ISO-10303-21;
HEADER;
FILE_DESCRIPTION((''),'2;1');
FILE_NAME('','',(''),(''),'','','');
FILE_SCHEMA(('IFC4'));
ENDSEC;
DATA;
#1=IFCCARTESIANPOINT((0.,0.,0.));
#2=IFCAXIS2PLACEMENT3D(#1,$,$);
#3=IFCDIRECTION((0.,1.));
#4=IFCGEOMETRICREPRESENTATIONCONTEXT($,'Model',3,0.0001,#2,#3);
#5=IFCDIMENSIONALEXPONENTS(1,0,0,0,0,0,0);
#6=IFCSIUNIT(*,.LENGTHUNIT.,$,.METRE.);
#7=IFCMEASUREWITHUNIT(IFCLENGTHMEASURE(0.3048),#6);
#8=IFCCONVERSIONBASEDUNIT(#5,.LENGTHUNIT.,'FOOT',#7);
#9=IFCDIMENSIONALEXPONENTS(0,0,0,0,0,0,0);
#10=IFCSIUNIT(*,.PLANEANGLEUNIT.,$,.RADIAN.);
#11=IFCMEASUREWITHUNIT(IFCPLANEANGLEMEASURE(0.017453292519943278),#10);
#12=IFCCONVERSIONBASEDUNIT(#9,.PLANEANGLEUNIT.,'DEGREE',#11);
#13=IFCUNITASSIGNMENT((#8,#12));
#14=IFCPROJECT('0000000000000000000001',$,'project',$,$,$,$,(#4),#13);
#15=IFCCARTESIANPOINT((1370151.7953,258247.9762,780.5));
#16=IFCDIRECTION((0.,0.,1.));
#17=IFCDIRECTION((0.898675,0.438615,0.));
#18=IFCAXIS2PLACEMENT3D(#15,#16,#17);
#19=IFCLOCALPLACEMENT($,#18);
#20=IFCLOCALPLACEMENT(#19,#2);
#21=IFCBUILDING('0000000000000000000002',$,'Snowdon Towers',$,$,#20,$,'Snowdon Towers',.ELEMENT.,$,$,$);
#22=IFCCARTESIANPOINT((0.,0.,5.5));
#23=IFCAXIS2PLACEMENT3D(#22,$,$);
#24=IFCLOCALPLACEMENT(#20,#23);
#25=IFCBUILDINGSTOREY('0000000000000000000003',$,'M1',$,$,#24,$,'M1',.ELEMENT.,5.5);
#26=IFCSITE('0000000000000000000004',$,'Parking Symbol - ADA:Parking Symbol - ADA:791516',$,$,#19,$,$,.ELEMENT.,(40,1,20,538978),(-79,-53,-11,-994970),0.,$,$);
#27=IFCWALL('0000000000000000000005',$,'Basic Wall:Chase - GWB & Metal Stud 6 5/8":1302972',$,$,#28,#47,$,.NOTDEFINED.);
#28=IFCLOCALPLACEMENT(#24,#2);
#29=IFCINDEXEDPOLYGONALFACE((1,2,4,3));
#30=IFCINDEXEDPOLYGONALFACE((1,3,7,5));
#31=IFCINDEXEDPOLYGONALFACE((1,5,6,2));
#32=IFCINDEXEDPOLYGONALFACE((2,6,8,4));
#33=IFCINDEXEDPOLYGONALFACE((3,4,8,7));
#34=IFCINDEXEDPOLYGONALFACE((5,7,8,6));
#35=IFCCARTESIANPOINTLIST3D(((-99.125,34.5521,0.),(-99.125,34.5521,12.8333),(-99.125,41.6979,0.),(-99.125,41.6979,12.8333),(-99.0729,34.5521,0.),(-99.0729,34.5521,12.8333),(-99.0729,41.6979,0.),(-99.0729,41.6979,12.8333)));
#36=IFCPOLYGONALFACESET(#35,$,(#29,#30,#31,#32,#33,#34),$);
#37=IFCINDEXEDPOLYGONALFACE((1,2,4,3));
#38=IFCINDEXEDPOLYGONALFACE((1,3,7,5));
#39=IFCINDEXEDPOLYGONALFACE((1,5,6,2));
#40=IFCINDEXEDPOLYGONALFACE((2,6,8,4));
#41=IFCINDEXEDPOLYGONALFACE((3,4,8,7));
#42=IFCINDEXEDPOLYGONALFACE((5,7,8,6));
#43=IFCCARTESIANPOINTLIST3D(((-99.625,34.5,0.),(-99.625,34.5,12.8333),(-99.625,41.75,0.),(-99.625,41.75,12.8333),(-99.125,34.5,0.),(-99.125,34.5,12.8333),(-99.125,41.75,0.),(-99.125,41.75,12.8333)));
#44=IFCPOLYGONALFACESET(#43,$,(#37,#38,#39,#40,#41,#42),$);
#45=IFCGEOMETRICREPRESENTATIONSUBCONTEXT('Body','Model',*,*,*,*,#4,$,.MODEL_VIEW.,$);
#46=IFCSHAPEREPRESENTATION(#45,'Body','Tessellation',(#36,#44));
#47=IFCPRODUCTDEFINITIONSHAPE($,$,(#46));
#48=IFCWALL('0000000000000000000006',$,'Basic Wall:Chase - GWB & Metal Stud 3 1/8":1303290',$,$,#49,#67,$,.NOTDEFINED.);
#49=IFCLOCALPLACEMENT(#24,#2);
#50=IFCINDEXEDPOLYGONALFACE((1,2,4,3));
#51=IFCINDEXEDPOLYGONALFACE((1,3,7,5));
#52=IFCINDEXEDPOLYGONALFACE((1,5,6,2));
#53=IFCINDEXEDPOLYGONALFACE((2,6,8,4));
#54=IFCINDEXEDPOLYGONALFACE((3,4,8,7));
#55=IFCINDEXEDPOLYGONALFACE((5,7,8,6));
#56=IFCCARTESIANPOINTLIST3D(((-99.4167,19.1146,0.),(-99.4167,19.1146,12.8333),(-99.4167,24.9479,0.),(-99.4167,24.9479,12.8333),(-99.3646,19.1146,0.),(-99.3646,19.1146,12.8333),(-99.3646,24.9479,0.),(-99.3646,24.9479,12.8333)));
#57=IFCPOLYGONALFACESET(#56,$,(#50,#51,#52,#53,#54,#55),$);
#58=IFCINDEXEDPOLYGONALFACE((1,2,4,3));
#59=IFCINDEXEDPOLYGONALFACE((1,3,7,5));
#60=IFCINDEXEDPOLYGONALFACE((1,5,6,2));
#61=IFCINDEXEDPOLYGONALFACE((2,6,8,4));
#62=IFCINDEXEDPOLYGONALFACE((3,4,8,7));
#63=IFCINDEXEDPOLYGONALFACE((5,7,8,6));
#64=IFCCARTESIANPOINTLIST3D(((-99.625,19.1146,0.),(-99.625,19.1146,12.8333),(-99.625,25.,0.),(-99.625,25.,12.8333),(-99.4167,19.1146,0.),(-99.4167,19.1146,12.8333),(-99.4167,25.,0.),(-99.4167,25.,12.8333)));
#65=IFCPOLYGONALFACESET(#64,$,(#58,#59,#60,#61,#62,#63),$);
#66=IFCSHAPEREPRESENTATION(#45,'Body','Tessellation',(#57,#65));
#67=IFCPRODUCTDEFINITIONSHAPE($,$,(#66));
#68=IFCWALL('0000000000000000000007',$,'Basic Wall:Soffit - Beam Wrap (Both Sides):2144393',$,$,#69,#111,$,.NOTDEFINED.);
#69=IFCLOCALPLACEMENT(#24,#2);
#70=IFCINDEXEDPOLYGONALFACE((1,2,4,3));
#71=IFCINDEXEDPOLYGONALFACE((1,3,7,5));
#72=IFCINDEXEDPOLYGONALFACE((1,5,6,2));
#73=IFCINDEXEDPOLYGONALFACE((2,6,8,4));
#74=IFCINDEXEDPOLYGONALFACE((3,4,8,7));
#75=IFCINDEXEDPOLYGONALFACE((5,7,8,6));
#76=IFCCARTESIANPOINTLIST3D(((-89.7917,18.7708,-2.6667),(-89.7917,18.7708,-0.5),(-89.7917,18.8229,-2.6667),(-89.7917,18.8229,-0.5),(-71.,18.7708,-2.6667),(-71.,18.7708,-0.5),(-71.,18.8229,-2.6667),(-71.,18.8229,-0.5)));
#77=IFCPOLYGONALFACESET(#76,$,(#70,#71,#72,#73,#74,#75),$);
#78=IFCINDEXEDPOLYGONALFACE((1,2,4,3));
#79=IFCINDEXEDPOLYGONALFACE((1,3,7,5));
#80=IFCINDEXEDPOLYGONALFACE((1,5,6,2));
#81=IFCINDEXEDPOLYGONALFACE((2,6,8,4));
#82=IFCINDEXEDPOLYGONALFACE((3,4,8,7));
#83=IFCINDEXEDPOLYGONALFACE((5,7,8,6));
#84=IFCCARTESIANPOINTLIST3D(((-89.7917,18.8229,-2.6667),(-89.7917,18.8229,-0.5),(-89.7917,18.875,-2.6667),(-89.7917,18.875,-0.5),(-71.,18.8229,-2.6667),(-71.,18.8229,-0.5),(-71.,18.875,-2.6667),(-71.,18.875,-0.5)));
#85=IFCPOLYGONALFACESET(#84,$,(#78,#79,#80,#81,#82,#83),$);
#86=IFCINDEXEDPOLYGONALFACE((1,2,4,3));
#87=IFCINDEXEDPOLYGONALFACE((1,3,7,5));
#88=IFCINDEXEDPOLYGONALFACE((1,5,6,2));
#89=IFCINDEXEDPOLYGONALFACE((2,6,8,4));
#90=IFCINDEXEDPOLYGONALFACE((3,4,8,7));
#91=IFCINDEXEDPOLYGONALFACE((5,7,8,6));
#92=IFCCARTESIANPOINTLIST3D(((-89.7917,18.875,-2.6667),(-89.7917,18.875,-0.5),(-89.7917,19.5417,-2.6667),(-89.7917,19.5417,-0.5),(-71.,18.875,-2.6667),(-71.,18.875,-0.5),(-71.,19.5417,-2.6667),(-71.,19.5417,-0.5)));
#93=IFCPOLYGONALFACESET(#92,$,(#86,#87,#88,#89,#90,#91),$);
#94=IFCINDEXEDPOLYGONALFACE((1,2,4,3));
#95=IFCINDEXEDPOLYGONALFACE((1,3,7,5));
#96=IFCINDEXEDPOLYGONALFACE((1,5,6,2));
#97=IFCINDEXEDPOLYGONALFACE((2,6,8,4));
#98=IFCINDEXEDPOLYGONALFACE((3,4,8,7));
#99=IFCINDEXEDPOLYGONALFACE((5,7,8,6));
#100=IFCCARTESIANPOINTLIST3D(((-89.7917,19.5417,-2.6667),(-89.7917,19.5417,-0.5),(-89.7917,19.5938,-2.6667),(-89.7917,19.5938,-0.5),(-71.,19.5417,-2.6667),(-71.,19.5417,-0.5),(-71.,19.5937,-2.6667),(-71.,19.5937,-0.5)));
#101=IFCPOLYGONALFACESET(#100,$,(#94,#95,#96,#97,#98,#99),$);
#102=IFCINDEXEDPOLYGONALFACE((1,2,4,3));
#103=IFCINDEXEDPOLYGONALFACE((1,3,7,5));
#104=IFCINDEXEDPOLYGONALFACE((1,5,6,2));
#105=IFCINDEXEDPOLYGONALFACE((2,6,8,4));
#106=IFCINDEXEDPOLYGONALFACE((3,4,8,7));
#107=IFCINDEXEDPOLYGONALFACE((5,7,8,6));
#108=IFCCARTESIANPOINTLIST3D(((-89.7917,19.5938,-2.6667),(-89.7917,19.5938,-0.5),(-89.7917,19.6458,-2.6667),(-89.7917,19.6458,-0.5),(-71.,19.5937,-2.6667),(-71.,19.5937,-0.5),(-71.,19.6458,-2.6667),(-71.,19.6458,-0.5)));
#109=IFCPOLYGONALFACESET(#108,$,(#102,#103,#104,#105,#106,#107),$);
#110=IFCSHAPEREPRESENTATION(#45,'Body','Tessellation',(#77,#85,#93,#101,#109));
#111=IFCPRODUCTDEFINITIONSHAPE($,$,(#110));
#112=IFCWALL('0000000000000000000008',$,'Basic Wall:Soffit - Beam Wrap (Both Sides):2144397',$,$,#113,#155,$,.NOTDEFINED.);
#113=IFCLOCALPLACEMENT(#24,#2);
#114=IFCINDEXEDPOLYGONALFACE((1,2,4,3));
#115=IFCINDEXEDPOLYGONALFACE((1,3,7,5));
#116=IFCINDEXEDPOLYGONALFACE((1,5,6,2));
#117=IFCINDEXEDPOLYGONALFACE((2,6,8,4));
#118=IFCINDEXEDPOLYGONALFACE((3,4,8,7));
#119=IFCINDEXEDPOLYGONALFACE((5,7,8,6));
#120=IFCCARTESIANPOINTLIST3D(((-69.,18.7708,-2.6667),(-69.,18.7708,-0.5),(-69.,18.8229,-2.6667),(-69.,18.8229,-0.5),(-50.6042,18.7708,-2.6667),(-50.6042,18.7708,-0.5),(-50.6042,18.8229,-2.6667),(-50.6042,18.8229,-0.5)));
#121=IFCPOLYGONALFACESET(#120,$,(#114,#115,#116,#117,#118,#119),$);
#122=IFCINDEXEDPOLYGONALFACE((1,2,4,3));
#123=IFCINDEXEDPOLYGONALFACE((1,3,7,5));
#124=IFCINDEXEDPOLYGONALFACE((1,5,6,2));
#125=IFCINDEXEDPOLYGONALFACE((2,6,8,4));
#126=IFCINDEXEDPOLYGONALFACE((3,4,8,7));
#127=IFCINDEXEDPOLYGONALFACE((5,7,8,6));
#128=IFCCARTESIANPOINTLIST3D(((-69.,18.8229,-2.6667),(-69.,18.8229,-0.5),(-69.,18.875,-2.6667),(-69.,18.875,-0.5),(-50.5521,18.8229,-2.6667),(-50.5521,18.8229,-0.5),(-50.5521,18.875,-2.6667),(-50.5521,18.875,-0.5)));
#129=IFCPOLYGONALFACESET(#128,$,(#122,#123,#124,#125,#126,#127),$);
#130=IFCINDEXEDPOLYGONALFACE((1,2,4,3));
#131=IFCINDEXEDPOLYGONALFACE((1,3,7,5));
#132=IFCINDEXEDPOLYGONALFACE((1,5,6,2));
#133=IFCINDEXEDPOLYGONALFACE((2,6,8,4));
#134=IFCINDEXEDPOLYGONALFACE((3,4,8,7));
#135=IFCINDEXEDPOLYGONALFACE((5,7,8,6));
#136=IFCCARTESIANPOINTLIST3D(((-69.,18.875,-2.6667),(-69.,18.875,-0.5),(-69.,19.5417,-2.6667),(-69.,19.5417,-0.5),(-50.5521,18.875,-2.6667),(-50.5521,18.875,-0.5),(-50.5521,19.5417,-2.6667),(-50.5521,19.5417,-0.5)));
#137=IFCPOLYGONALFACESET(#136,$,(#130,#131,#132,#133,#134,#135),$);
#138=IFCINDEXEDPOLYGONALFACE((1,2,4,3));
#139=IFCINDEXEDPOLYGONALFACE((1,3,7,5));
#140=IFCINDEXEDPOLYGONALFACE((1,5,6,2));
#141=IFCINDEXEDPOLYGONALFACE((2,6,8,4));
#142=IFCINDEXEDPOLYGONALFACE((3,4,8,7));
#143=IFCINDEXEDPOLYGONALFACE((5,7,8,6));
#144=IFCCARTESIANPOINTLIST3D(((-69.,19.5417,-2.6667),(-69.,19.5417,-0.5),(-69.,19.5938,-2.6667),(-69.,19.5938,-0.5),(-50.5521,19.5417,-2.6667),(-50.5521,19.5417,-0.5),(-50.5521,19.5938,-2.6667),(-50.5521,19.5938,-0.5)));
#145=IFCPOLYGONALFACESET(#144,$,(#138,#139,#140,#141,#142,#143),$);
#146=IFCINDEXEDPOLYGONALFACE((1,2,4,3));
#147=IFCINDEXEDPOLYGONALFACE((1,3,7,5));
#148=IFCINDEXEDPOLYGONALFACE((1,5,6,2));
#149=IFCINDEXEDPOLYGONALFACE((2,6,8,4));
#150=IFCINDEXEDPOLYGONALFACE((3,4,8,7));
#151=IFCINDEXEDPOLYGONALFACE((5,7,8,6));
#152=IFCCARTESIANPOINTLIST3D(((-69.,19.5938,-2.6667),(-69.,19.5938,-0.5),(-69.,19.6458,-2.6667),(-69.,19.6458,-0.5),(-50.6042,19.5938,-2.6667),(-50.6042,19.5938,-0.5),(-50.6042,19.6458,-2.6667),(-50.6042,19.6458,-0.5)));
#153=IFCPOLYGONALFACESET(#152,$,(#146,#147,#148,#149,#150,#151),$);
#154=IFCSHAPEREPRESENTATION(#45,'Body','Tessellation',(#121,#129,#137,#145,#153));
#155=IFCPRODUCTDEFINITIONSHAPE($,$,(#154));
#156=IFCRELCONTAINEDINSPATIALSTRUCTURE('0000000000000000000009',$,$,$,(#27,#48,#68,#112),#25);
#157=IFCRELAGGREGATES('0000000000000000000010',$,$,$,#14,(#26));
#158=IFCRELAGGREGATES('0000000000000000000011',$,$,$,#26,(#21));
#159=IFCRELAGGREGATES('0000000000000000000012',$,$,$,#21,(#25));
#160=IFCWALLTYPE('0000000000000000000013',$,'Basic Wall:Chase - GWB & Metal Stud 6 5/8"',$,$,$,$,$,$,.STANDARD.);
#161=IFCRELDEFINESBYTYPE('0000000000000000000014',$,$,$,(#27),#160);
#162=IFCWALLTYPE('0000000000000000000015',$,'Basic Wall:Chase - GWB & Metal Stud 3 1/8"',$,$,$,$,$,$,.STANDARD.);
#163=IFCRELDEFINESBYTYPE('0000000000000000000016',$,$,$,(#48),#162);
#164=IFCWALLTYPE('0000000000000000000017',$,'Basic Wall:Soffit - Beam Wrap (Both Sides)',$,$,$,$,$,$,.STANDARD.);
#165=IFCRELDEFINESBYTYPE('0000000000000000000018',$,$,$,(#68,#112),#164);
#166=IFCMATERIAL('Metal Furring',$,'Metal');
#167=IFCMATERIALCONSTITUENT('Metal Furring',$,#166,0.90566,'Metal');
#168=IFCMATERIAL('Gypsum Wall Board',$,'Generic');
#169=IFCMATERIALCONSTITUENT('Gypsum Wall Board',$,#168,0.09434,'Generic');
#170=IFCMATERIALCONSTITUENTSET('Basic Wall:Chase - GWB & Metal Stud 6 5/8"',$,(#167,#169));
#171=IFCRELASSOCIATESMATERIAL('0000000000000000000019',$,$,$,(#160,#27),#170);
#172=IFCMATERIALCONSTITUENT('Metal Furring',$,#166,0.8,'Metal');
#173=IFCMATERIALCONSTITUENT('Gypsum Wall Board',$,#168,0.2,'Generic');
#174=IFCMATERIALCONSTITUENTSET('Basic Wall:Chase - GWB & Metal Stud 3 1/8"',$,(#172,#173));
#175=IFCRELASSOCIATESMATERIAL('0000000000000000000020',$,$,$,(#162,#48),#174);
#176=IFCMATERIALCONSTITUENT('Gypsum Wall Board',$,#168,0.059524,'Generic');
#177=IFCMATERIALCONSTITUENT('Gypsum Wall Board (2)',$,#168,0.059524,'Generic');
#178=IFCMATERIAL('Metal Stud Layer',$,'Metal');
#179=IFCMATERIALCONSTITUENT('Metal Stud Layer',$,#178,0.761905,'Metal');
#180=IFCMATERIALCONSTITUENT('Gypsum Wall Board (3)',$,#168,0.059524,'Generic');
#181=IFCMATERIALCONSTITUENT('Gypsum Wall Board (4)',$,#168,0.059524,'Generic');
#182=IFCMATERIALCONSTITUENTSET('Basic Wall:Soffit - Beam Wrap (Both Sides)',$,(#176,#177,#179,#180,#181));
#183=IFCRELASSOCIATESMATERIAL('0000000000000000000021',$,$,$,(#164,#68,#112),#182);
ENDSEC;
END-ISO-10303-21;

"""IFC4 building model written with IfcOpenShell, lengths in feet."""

from ifc_helpers import new_model, entity, si_unit, converted_unit, direction, frame, origin, place, context, subcontext, project, spatial, indexed_curve, outline, extrude, material, constituent, constituent_set, type_object, element, save


model = new_model("IFC4")

# Units and contexts
model_context = context("Model", 3, precision=0.0001, world=origin(), true_north=direction((0.0, 1.0)))
body_context = subcontext(model_context, "Body", "Model", "MODEL_VIEW")
ifc_project = project(units=[converted_unit("LENGTHUNIT", "FOOT", entity("IfcLengthMeasure", 0.3048), si_unit("LENGTHUNIT", "METRE"), dimensions=[1, 0, 0, 0, 0, 0, 0]), converted_unit("PLANEANGLEUNIT", "DEGREE", entity("IfcPlaneAngleMeasure", 0.017453292519943278), si_unit("PLANEANGLEUNIT", "RADIAN"), dimensions=[0, 0, 0, 0, 0, 0, 0])], contexts=[model_context])

# Site, building, storey
site_placement = place(None, frame((1370151.7953, 258247.9762, 780.5), z_axis=(0.0, 0.0, 1.0), x_axis=(0.898675, 0.438615, 0.0)))
site = spatial("IfcSite", under=ifc_project, at=site_placement, Name="Parking Symbol - ADA:Parking Symbol - ADA:791516", CompositionType="ELEMENT", RefLatitude=(40, 1, 20, 538978), RefLongitude=(-79, -53, -11, -994970), RefElevation=0.0)
building_placement = place(site_placement, origin())
building = spatial("IfcBuilding", under=site, at=building_placement, Name="Snowdon Towers", LongName="Snowdon Towers", CompositionType="ELEMENT")
storey_placement = place(building_placement, frame((0.0, 0.0, 5.5)))
storey = spatial("IfcBuildingStorey", under=building, at=storey_placement, Name="M1", LongName="M1", CompositionType="ELEMENT", Elevation=5.5)

# Wall
ifc_material_1 = material(Name="Metal Furring", Category="Metal")
ifc_material_2 = material(Name="Gypsum Wall Board", Category="Generic")
ifc_constituent_1 = constituent(ifc_material_1, Name="Metal Furring", Category="Metal", fraction=0.90566)
ifc_constituent_2 = constituent(ifc_material_2, Name="Gypsum Wall Board", Category="Generic", fraction=0.09434)
ifc_constituent_set_1 = constituent_set(constituents=[ifc_constituent_1, ifc_constituent_2], Name="Basic Wall:Chase - GWB & Metal Stud 6 5/8\"")
wall_type_1 = type_object("IfcWallType", Name="Basic Wall:Chase - GWB & Metal Stud 6 5/8\"", PredefinedType="STANDARD", material=ifc_constituent_set_1)
wall_1_placement = place(storey_placement, frame((-99.349, 41.6979, 0.0), z_axis=(0.0, 0.0, 1.0), x_axis=(0.0, -1.0, 0.0)))
element("IfcWall", 1, at=wall_1_placement, inside=storey, type_object=wall_type_1, material=ifc_constituent_set_1, Name="Basic Wall:Chase - GWB & Metal Stud 6 5/8\":1302972", PredefinedType="NOTDEFINED", context=body_context, shape_type="SweptSolid", body=[
    extrude(outline(indexed_curve([(-0.026, -3.5729), (0.026, -3.5729), (0.026, 3.5729), (-0.026, 3.5729), (-0.026, -3.5729)], self_intersect=False)), frame((3.5729, 0.25, 0.0), z_axis=(0.0, 0.0, 1.0), x_axis=(0.0, -1.0, 0.0)), (0.0, 0.0, 1.0), 12.8333),
    extrude(outline(indexed_curve([(-0.25, -3.625), (0.25, -3.625), (0.25, 3.625), (-0.25, 3.625), (-0.25, -3.625)], self_intersect=False)), frame((3.5729, -0.026, 0.0), z_axis=(0.0, 0.0, 1.0), x_axis=(0.0, -1.0, 0.0)), (0.0, 0.0, 1.0), 12.8333),
])
ifc_constituent_3 = constituent(ifc_material_1, Name="Metal Furring", Category="Metal", fraction=0.8)
ifc_constituent_4 = constituent(ifc_material_2, Name="Gypsum Wall Board", Category="Generic", fraction=0.2)
ifc_constituent_set_2 = constituent_set(constituents=[ifc_constituent_3, ifc_constituent_4], Name="Basic Wall:Chase - GWB & Metal Stud 3 1/8\"")
wall_type_2 = type_object("IfcWallType", Name="Basic Wall:Chase - GWB & Metal Stud 3 1/8\"", PredefinedType="STANDARD", material=ifc_constituent_set_2)

# Walls
wall_2_placement = place(storey_placement, frame((-99.4948, 24.9479, 0.0), z_axis=(0.0, 0.0, 1.0), x_axis=(0.0, -1.0, 0.0)))
element("IfcWall", 2, at=wall_2_placement, inside=storey, type_object=wall_type_2, material=ifc_constituent_set_2, Name="Basic Wall:Chase - GWB & Metal Stud 3 1/8\":1303290", PredefinedType="NOTDEFINED", context=body_context, shape_type="SweptSolid", body=[
    extrude(outline(indexed_curve([(-0.026, -2.9167), (0.026, -2.9167), (0.026, 2.9167), (-0.026, 2.9167), (-0.026, -2.9167)], self_intersect=False)), frame((2.9167, 0.1042, 0.0), z_axis=(0.0, 0.0, 1.0), x_axis=(0.0, -1.0, 0.0)), (0.0, 0.0, 1.0), 12.8333),
    extrude(outline(indexed_curve([(-0.1042, -2.9427), (0.1042, -2.9427), (0.1042, 2.9427), (-0.1042, 2.9427), (-0.1042, -2.9427)], self_intersect=False)), frame((2.8906, -0.026, 0.0), z_axis=(0.0, 0.0, 1.0), x_axis=(0.0, 1.0, 0.0)), (0.0, 0.0, 1.0), 12.8333),
])
ifc_constituent_5 = constituent(ifc_material_2, Name="Gypsum Wall Board", Category="Generic", fraction=0.059524)
ifc_constituent_6 = constituent(ifc_material_2, Name="Gypsum Wall Board (2)", Category="Generic", fraction=0.059524)
ifc_material_3 = material(Name="Metal Stud Layer", Category="Metal")
ifc_constituent_7 = constituent(ifc_material_3, Name="Metal Stud Layer", Category="Metal", fraction=0.761905)
ifc_constituent_8 = constituent(ifc_material_2, Name="Gypsum Wall Board (3)", Category="Generic", fraction=0.059524)
ifc_constituent_9 = constituent(ifc_material_2, Name="Gypsum Wall Board (4)", Category="Generic", fraction=0.059524)
ifc_constituent_set_3 = constituent_set(constituents=[ifc_constituent_5, ifc_constituent_6, ifc_constituent_7, ifc_constituent_8, ifc_constituent_9], Name="Basic Wall:Soffit - Beam Wrap (Both Sides)")
wall_type_3 = type_object("IfcWallType", Name="Basic Wall:Soffit - Beam Wrap (Both Sides)", PredefinedType="STANDARD", material=ifc_constituent_set_3)
wall_3_placement = place(storey_placement, frame((-89.7917, 19.2083, -2.6667)))
element("IfcWall", 3, at=wall_3_placement, inside=storey, type_object=wall_type_3, material=ifc_constituent_set_3, Name="Basic Wall:Soffit - Beam Wrap (Both Sides):2144393", PredefinedType="NOTDEFINED", context=body_context, shape_type="SweptSolid", body=[
    extrude(outline(indexed_curve([(-0.026, -9.3958), (0.026, -9.3958), (0.026, 9.3958), (-0.026, 9.3958), (-0.026, -9.3958)], self_intersect=False)), frame((9.3958, -0.4115, 0.0), z_axis=(0.0, 0.0, 1.0), x_axis=(0.0, 1.0, 0.0)), (0.0, 0.0, 1.0), 2.1667),
    extrude(outline(indexed_curve([(-9.3958, -0.026), (9.3958, -0.026), (9.3958, 0.026), (-9.3958, 0.026), (-9.3958, -0.026)], self_intersect=False)), frame((9.3958, -0.3594, 0.0)), (0.0, 0.0, 1.0), 2.1667),
    extrude(outline(indexed_curve([(-9.3958, -0.3333), (9.3958, -0.3333), (9.3958, 0.3333), (-9.3958, 0.3333), (-9.3958, -0.3333)], self_intersect=False)), frame((9.3958, 0.0, 0.0)), (0.0, 0.0, 1.0), 2.1667),
    extrude(outline(indexed_curve([(-9.3958, -0.026), (9.3958, -0.026), (9.3958, 0.026), (-9.3958, 0.026), (-9.3958, -0.026)], self_intersect=False)), frame((9.3958, 0.3594, 0.0)), (0.0, 0.0, 1.0), 2.1667),
    extrude(outline(indexed_curve([(-0.026, -9.3958), (0.026, -9.3958), (0.026, 9.3958), (-0.026, 9.3958), (-0.026, -9.3958)], self_intersect=False)), frame((9.3958, 0.4115, 0.0), z_axis=(0.0, 0.0, 1.0), x_axis=(0.0, -1.0, 0.0)), (0.0, 0.0, 1.0), 2.1667),
])
wall_4_placement = place(storey_placement, frame((-69.0, 19.2083, -2.6667)))
element("IfcWall", 4, at=wall_4_placement, inside=storey, type_object=wall_type_3, material=ifc_constituent_set_3, Name="Basic Wall:Soffit - Beam Wrap (Both Sides):2144397", PredefinedType="NOTDEFINED", context=body_context, shape_type="SweptSolid", body=[
    extrude(outline(indexed_curve([(-0.026, -9.1979), (0.026, -9.1979), (0.026, 9.1979), (-0.026, 9.1979), (-0.026, -9.1979)], self_intersect=False)), frame((9.1979, -0.4115, 0.0), z_axis=(0.0, 0.0, 1.0), x_axis=(0.0, 1.0, 0.0)), (0.0, 0.0, 1.0), 2.1667),
    extrude(outline(indexed_curve([(-9.224, -0.026), (9.224, -0.026), (9.224, 0.026), (-9.224, 0.026), (-9.224, -0.026)], self_intersect=False)), frame((9.224, -0.3594, 0.0)), (0.0, 0.0, 1.0), 2.1667),
    extrude(outline(indexed_curve([(-9.224, -0.3333), (9.224, -0.3333), (9.224, 0.3333), (-9.224, 0.3333), (-9.224, -0.3333)], self_intersect=False)), frame((9.224, 0.0, 0.0)), (0.0, 0.0, 1.0), 2.1667),
    extrude(outline(indexed_curve([(-9.224, -0.026), (9.224, -0.026), (9.224, 0.026), (-9.224, 0.026), (-9.224, -0.026)], self_intersect=False)), frame((9.224, 0.3594, 0.0)), (0.0, 0.0, 1.0), 2.1667),
    extrude(outline(indexed_curve([(-0.026, -9.1979), (0.026, -9.1979), (0.026, 9.1979), (-0.026, 9.1979), (-0.026, -9.1979)], self_intersect=False)), frame((9.1979, 0.4115, 0.0), z_axis=(0.0, 0.0, 1.0), x_axis=(0.0, -1.0, 0.0)), (0.0, 0.0, 1.0), 2.1667),
])

save(model, "model.ifc")
